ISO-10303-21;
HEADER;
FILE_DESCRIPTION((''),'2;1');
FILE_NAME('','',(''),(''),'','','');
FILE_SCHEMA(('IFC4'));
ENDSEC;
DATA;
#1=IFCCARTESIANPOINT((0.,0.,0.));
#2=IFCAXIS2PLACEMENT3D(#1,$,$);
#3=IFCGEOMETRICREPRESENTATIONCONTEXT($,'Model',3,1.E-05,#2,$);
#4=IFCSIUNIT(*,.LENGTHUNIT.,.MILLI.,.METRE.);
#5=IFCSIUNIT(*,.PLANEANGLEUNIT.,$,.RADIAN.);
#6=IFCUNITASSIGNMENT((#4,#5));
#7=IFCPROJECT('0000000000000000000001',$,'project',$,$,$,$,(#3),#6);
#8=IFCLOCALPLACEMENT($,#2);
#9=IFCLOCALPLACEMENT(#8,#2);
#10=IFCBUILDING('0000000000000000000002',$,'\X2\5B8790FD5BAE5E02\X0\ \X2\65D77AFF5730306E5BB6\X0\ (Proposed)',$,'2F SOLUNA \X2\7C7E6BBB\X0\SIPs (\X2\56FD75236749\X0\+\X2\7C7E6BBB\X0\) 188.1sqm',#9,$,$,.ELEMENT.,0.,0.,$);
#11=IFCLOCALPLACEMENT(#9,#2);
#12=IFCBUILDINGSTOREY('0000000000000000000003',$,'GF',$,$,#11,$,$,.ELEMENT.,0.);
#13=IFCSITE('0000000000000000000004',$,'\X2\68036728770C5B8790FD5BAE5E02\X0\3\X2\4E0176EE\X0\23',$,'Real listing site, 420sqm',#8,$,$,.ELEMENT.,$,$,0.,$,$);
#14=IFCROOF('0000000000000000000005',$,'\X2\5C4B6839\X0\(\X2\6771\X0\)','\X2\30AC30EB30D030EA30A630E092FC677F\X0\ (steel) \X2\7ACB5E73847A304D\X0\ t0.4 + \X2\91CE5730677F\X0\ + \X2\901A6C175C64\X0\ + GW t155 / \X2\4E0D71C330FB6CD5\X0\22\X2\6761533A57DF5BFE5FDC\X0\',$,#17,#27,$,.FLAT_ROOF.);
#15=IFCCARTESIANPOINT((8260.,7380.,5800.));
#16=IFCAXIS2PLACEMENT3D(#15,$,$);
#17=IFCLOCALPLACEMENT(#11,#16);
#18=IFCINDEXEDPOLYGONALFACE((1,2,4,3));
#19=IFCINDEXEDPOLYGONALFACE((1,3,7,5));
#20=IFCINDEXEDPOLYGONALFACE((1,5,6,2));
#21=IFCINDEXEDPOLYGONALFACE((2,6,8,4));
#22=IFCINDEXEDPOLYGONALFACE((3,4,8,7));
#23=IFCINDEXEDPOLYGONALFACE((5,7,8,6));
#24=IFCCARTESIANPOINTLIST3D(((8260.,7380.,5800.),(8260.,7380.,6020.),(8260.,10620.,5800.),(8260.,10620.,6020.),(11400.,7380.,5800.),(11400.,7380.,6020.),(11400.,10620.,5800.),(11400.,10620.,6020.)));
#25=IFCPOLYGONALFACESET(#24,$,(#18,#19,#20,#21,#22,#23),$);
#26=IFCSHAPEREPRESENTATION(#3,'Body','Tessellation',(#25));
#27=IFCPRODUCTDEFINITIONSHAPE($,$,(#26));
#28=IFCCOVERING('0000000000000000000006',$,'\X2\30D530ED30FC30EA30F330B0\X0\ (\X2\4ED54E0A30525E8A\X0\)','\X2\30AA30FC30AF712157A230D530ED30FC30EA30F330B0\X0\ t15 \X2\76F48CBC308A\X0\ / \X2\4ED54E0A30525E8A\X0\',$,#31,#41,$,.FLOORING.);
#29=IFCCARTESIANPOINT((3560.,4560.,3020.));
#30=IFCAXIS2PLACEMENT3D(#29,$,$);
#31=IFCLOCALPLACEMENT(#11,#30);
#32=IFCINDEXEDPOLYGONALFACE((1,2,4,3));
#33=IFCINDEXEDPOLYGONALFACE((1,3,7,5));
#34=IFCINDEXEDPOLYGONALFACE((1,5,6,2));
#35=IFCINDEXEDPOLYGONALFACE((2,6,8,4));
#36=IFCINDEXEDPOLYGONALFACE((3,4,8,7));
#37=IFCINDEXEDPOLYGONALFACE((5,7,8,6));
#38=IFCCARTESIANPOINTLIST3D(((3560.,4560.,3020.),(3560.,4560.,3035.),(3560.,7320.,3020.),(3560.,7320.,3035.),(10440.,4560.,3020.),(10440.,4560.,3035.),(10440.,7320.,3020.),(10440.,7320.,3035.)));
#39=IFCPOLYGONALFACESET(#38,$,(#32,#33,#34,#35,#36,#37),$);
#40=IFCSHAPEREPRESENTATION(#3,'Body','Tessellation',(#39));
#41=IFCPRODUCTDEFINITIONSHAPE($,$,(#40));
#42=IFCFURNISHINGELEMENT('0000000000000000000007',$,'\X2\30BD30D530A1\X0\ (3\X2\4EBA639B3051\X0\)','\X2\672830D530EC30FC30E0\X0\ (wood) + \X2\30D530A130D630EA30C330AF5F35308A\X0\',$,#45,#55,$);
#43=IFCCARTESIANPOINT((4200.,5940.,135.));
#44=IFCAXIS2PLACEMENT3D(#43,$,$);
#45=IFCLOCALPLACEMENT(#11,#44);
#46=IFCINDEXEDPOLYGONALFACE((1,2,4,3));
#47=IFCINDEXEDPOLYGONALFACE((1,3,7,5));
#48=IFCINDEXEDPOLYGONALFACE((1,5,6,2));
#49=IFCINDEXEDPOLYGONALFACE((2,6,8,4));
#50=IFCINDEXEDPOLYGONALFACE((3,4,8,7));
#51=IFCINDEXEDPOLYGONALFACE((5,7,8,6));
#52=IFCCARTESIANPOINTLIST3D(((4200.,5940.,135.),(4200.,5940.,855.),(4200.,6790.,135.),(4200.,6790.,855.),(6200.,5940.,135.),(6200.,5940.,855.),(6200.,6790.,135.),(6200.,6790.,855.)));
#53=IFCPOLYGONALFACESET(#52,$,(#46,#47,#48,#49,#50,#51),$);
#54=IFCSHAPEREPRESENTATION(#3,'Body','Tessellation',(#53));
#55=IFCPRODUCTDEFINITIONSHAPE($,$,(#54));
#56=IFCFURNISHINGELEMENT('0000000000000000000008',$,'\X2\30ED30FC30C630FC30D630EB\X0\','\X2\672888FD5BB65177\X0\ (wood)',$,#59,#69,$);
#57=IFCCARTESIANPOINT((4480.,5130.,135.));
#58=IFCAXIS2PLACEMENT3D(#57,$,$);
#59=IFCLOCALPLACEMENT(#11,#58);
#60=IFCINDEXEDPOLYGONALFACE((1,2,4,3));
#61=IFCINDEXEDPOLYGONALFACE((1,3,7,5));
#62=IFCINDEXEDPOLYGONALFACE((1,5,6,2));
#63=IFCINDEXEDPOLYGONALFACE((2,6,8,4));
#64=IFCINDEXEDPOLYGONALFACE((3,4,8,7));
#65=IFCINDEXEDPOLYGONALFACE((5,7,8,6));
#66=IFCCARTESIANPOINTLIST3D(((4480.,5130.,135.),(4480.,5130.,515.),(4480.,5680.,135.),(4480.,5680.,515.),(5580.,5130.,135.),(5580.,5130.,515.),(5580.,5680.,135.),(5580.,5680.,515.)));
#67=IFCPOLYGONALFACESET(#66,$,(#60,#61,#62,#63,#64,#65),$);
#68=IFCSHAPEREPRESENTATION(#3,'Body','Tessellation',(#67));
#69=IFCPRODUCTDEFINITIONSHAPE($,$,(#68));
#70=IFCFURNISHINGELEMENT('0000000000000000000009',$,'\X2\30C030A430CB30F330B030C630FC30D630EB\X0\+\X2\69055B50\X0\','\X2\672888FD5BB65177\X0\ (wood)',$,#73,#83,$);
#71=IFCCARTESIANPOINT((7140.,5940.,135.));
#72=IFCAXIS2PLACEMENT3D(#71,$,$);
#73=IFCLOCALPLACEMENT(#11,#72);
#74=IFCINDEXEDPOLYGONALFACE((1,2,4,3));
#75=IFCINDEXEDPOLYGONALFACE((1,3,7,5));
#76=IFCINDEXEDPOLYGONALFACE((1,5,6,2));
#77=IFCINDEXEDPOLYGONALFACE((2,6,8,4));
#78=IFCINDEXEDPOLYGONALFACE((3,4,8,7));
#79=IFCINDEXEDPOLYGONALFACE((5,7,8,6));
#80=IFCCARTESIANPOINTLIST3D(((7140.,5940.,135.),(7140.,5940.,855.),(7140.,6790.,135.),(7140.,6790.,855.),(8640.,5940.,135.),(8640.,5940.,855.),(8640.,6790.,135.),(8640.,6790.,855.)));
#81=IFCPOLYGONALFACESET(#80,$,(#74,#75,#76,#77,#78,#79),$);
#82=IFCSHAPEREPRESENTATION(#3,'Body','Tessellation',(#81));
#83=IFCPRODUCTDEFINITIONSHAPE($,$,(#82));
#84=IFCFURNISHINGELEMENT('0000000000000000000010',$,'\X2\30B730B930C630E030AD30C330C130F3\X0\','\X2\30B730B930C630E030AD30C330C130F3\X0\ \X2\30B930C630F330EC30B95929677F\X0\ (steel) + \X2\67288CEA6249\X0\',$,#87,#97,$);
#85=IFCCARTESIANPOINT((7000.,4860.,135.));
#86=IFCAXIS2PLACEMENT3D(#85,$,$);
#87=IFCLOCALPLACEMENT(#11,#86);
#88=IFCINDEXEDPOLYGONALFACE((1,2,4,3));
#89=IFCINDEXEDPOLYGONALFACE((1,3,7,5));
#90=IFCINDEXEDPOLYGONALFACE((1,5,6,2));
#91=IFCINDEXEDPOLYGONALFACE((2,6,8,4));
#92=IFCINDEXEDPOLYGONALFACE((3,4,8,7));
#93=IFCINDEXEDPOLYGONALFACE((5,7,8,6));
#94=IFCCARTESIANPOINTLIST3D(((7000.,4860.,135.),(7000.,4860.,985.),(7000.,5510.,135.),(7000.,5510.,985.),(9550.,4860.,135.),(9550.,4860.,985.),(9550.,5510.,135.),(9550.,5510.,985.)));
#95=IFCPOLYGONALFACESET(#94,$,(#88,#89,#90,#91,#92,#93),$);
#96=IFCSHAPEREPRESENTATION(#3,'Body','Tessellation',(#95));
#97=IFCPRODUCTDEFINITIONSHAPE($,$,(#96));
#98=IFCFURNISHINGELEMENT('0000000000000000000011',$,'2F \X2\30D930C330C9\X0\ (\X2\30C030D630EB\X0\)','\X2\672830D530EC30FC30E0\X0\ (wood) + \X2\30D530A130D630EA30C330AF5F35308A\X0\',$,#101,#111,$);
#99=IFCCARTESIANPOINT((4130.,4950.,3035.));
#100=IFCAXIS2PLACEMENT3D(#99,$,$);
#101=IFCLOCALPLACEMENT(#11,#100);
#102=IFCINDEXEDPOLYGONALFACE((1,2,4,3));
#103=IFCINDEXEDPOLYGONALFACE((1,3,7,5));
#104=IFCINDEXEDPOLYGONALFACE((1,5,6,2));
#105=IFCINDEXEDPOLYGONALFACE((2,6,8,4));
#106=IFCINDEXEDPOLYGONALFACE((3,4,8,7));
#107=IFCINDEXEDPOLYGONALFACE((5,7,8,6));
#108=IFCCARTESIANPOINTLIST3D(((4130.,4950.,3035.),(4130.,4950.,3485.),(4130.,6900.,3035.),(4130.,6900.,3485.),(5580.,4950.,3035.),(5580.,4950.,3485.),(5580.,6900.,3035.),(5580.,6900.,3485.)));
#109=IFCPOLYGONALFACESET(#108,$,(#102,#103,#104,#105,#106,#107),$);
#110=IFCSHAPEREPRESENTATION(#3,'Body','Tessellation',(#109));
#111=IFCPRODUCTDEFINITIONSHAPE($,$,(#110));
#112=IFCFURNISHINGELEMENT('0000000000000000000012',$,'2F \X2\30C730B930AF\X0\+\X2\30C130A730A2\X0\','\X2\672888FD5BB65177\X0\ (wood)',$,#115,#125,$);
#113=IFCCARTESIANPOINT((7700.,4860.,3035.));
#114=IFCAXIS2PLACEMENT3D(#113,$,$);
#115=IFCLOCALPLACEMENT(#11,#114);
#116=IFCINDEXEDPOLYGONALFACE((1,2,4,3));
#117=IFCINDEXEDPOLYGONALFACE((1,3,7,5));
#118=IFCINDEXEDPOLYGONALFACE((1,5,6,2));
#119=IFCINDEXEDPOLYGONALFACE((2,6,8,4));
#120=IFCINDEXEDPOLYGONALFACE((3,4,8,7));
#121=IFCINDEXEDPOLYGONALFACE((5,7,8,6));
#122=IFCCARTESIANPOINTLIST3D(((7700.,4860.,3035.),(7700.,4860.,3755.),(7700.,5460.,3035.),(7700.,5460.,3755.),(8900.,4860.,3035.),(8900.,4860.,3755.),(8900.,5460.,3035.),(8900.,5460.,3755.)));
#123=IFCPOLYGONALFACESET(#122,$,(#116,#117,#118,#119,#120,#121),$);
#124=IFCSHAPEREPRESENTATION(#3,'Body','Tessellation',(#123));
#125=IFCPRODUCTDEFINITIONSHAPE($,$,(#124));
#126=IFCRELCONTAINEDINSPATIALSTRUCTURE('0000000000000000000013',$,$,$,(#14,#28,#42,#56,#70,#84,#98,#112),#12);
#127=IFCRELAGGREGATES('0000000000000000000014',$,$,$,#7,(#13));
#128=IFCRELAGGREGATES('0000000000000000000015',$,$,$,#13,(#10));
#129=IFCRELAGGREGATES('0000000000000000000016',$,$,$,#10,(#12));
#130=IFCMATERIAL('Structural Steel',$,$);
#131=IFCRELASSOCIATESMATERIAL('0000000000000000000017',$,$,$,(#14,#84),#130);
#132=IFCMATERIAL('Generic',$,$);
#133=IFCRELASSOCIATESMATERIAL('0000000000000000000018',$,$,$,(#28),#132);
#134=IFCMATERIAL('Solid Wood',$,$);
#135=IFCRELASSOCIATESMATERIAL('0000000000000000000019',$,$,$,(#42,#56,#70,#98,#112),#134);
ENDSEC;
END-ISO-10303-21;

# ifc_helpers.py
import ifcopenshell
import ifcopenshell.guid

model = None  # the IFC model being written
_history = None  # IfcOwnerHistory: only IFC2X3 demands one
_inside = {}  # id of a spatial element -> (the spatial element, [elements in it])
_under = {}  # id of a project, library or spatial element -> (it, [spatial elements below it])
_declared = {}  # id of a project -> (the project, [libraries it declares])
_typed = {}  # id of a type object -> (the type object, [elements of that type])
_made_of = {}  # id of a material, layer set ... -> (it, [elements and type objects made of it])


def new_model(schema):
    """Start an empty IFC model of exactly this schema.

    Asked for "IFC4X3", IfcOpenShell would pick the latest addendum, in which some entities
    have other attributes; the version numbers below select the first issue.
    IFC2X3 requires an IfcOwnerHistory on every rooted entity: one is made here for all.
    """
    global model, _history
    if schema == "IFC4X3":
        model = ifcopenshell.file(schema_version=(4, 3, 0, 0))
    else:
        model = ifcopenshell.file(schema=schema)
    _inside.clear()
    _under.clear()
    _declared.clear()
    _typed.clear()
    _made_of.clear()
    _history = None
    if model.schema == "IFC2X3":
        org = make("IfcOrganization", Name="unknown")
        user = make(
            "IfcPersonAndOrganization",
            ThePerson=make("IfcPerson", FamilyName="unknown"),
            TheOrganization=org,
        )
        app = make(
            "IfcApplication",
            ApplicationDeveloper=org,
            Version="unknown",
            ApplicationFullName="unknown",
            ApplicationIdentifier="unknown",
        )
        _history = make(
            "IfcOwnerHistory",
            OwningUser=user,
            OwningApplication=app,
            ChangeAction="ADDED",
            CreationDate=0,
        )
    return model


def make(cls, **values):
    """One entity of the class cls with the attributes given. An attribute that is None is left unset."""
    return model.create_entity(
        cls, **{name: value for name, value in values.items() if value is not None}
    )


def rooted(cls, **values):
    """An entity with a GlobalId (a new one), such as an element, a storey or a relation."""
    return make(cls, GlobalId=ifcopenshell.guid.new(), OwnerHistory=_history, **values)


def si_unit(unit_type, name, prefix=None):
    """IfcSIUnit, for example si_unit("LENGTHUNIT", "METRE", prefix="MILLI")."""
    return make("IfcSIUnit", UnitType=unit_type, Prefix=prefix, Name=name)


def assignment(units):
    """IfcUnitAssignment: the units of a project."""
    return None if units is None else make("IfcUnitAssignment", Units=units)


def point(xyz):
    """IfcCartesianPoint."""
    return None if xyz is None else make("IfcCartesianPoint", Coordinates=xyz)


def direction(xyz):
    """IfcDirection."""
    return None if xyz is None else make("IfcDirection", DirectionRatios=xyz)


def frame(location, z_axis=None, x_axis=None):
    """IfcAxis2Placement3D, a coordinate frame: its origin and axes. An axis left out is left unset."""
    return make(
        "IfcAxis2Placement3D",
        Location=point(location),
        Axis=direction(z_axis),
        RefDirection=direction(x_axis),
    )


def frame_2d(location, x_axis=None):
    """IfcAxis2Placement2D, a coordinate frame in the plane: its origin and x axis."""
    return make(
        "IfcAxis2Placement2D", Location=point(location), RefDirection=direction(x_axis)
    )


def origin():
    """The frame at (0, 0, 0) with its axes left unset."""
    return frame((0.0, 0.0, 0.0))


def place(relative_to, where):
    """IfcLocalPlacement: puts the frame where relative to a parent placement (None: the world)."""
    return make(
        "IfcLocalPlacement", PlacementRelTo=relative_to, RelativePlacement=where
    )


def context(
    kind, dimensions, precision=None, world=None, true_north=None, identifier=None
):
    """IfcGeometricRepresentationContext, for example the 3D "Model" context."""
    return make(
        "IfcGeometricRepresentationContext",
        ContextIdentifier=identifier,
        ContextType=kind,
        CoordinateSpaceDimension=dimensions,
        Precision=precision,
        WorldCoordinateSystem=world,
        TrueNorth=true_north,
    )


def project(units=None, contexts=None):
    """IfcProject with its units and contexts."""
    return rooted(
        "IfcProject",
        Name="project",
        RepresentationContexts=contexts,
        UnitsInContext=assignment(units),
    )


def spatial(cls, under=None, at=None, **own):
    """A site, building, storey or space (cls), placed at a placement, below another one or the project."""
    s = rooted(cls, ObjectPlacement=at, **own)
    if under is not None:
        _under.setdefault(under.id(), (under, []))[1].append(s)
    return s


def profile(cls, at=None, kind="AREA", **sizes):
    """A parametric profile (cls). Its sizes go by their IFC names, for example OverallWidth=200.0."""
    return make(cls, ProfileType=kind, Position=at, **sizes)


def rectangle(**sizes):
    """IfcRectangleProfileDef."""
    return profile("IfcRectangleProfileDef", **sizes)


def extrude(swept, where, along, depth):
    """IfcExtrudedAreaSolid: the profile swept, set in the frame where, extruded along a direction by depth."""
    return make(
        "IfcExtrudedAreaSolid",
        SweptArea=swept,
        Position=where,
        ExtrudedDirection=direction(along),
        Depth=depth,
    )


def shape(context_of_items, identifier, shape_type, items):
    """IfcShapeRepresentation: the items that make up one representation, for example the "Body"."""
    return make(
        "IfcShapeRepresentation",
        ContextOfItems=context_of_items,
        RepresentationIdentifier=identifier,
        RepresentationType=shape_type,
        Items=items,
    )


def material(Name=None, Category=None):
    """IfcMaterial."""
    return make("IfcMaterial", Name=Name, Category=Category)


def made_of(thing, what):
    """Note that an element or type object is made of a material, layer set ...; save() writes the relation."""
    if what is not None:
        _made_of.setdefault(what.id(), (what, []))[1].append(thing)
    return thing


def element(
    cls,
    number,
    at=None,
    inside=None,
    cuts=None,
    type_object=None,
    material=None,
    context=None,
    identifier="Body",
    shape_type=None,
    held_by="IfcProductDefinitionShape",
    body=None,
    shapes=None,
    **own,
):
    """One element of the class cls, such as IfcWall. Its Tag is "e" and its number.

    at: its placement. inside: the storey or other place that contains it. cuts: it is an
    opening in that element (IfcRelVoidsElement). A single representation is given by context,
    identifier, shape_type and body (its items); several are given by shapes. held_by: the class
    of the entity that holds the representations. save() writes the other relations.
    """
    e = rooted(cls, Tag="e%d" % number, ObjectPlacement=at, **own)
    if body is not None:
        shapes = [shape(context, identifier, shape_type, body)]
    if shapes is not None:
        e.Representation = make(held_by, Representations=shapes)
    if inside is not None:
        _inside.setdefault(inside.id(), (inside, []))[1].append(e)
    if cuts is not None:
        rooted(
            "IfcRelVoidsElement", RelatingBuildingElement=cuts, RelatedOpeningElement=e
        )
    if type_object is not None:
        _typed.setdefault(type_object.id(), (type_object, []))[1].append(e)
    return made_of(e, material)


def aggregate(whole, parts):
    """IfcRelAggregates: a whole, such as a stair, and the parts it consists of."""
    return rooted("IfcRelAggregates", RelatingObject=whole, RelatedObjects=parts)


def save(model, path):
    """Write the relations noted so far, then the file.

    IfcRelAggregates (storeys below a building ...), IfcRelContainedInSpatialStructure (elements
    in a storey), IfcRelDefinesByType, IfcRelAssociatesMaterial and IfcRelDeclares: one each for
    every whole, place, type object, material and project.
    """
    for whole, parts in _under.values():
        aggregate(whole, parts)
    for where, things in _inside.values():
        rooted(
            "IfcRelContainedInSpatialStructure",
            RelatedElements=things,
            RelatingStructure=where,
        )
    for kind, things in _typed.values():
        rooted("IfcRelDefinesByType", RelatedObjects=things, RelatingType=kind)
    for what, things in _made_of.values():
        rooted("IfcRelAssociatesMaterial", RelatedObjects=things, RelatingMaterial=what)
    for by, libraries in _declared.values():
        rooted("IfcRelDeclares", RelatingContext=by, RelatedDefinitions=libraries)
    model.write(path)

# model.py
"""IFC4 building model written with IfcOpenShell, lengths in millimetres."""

from ifc_helpers import new_model, si_unit, frame, frame_2d, origin, place, context, project, spatial, rectangle, extrude, material, element, save


model = new_model("IFC4")

# Units and contexts
model_context = context("Model", 3, precision=1e-05, world=origin())
ifc_project = project(units=[si_unit("LENGTHUNIT", "METRE", prefix="MILLI"), si_unit("PLANEANGLEUNIT", "RADIAN")], contexts=[model_context])

# Site, building, storey
site_placement = place(None, origin())
site = spatial("IfcSite", under=ifc_project, at=site_placement, Name="栃木県宇都宮市3丁目23", ObjectType="Real listing site, 420sqm", CompositionType="ELEMENT", RefElevation=0.0)
building_placement = place(site_placement, origin())
building = spatial("IfcBuilding", under=site, at=building_placement, Name="宇都宮市 旗竿地の家 (Proposed)", ObjectType="2F SOLUNA 籾殻SIPs (国産杉+籾殻) 188.1sqm", CompositionType="ELEMENT", ElevationOfRefHeight=0.0, ElevationOfTerrain=0.0)
storey_placement = place(building_placement, origin())
storey = spatial("IfcBuildingStorey", under=building, at=storey_placement, Name="GF", CompositionType="ELEMENT", Elevation=0.0)

# Shared definitions
ifc_material_1 = material(Name="Solid Wood")

# Shared definitions
ifc_material_2 = material(Name="Generic")

# Roof
ifc_material_3 = material(Name="Structural Steel")
roof_placement = place(storey_placement, frame((8260.0, 7380.0, 5800.0)))
element("IfcRoof", 1, at=roof_placement, inside=storey, material=ifc_material_3, Name="屋根(東)", Description="ガルバリウム鋼板 (steel) 立平葺き t0.4 + 野地板 + 通気層 + GW t155 / 不燃・法22条区域対応", PredefinedType="FLAT_ROOF", context=model_context, shape_type="SweptSolid", body=[
    extrude(rectangle(XDim=3140.0, YDim=3240.0, at=frame_2d((1570.0, 1620.0))), frame((8260.0, 7380.0, 5800.0)), (0.0, 0.0, 1.0), 220.0),
])

# Covering
covering_placement = place(storey_placement, frame((3560.0, 4560.0, 3020.0)))
element("IfcCovering", 2, at=covering_placement, inside=storey, material=ifc_material_2, Name="フローリング (仕上げ床)", Description="オーク無垢フローリング t15 直貼り / 仕上げ床", PredefinedType="FLOORING", context=model_context, shape_type="SweptSolid", body=[
    extrude(rectangle(XDim=6880.0, YDim=2760.0, at=frame_2d((3440.0, 1380.0))), frame((3560.0, 4560.0, 3020.0)), (0.0, 0.0, 1.0), 15.0),
])

# Furnishing elements
furnishing_1_placement = place(storey_placement, frame((4200.0, 5940.0, 135.0)))
element("IfcFurnishingElement", 3, at=furnishing_1_placement, inside=storey, material=ifc_material_1, Name="ソファ (3人掛け)", Description="木フレーム (wood) + ファブリック張り", context=model_context, shape_type="SweptSolid", body=[
    extrude(rectangle(XDim=2000.0, YDim=850.0, at=frame_2d((1000.0, 425.0))), frame((4200.0, 5940.0, 135.0)), (0.0, 0.0, 1.0), 720.0),
])
furnishing_2_placement = place(storey_placement, frame((4480.0, 5130.0, 135.0)))
element("IfcFurnishingElement", 4, at=furnishing_2_placement, inside=storey, material=ifc_material_1, Name="ローテーブル", Description="木製家具 (wood)", context=model_context, shape_type="SweptSolid", body=[
    extrude(rectangle(XDim=1100.0, YDim=550.0, at=frame_2d((550.0, 275.0))), frame((4480.0, 5130.0, 135.0)), (0.0, 0.0, 1.0), 380.0),
])
furnishing_3_placement = place(storey_placement, frame((7140.0, 5940.0, 135.0)))
element("IfcFurnishingElement", 5, at=furnishing_3_placement, inside=storey, material=ifc_material_1, Name="ダイニングテーブル+椅子", Description="木製家具 (wood)", context=model_context, shape_type="SweptSolid", body=[
    extrude(rectangle(XDim=1500.0, YDim=850.0, at=frame_2d((750.0, 425.0))), frame((7140.0, 5940.0, 135.0)), (0.0, 0.0, 1.0), 720.0),
])
furnishing_4_placement = place(storey_placement, frame((7000.0, 4860.0, 135.0)))
element("IfcFurnishingElement", 6, at=furnishing_4_placement, inside=storey, material=ifc_material_3, Name="システムキッチン", Description="システムキッチン ステンレス天板 (steel) + 木質扉", context=model_context, shape_type="SweptSolid", body=[
    extrude(rectangle(XDim=2550.0, YDim=650.0, at=frame_2d((1275.0, 325.0))), frame((7000.0, 4860.0, 135.0)), (0.0, 0.0, 1.0), 850.0),
])
furnishing_5_placement = place(storey_placement, frame((4130.0, 4950.0, 3035.0)))
element("IfcFurnishingElement", 7, at=furnishing_5_placement, inside=storey, material=ifc_material_1, Name="2F ベッド (ダブル)", Description="木フレーム (wood) + ファブリック張り", context=model_context, shape_type="SweptSolid", body=[
    extrude(rectangle(XDim=1450.0, YDim=1950.0, at=frame_2d((725.0, 975.0))), frame((4130.0, 4950.0, 3035.0)), (0.0, 0.0, 1.0), 450.0),
])
furnishing_6_placement = place(storey_placement, frame((7700.0, 4860.0, 3035.0)))
element("IfcFurnishingElement", 8, at=furnishing_6_placement, inside=storey, material=ifc_material_1, Name="2F デスク+チェア", Description="木製家具 (wood)", context=model_context, shape_type="SweptSolid", body=[
    extrude(rectangle(XDim=1200.0, YDim=600.0, at=frame_2d((600.0, 300.0))), frame((7700.0, 4860.0, 3035.0)), (0.0, 0.0, 1.0), 720.0),
])

save(model, "model.ifc")
